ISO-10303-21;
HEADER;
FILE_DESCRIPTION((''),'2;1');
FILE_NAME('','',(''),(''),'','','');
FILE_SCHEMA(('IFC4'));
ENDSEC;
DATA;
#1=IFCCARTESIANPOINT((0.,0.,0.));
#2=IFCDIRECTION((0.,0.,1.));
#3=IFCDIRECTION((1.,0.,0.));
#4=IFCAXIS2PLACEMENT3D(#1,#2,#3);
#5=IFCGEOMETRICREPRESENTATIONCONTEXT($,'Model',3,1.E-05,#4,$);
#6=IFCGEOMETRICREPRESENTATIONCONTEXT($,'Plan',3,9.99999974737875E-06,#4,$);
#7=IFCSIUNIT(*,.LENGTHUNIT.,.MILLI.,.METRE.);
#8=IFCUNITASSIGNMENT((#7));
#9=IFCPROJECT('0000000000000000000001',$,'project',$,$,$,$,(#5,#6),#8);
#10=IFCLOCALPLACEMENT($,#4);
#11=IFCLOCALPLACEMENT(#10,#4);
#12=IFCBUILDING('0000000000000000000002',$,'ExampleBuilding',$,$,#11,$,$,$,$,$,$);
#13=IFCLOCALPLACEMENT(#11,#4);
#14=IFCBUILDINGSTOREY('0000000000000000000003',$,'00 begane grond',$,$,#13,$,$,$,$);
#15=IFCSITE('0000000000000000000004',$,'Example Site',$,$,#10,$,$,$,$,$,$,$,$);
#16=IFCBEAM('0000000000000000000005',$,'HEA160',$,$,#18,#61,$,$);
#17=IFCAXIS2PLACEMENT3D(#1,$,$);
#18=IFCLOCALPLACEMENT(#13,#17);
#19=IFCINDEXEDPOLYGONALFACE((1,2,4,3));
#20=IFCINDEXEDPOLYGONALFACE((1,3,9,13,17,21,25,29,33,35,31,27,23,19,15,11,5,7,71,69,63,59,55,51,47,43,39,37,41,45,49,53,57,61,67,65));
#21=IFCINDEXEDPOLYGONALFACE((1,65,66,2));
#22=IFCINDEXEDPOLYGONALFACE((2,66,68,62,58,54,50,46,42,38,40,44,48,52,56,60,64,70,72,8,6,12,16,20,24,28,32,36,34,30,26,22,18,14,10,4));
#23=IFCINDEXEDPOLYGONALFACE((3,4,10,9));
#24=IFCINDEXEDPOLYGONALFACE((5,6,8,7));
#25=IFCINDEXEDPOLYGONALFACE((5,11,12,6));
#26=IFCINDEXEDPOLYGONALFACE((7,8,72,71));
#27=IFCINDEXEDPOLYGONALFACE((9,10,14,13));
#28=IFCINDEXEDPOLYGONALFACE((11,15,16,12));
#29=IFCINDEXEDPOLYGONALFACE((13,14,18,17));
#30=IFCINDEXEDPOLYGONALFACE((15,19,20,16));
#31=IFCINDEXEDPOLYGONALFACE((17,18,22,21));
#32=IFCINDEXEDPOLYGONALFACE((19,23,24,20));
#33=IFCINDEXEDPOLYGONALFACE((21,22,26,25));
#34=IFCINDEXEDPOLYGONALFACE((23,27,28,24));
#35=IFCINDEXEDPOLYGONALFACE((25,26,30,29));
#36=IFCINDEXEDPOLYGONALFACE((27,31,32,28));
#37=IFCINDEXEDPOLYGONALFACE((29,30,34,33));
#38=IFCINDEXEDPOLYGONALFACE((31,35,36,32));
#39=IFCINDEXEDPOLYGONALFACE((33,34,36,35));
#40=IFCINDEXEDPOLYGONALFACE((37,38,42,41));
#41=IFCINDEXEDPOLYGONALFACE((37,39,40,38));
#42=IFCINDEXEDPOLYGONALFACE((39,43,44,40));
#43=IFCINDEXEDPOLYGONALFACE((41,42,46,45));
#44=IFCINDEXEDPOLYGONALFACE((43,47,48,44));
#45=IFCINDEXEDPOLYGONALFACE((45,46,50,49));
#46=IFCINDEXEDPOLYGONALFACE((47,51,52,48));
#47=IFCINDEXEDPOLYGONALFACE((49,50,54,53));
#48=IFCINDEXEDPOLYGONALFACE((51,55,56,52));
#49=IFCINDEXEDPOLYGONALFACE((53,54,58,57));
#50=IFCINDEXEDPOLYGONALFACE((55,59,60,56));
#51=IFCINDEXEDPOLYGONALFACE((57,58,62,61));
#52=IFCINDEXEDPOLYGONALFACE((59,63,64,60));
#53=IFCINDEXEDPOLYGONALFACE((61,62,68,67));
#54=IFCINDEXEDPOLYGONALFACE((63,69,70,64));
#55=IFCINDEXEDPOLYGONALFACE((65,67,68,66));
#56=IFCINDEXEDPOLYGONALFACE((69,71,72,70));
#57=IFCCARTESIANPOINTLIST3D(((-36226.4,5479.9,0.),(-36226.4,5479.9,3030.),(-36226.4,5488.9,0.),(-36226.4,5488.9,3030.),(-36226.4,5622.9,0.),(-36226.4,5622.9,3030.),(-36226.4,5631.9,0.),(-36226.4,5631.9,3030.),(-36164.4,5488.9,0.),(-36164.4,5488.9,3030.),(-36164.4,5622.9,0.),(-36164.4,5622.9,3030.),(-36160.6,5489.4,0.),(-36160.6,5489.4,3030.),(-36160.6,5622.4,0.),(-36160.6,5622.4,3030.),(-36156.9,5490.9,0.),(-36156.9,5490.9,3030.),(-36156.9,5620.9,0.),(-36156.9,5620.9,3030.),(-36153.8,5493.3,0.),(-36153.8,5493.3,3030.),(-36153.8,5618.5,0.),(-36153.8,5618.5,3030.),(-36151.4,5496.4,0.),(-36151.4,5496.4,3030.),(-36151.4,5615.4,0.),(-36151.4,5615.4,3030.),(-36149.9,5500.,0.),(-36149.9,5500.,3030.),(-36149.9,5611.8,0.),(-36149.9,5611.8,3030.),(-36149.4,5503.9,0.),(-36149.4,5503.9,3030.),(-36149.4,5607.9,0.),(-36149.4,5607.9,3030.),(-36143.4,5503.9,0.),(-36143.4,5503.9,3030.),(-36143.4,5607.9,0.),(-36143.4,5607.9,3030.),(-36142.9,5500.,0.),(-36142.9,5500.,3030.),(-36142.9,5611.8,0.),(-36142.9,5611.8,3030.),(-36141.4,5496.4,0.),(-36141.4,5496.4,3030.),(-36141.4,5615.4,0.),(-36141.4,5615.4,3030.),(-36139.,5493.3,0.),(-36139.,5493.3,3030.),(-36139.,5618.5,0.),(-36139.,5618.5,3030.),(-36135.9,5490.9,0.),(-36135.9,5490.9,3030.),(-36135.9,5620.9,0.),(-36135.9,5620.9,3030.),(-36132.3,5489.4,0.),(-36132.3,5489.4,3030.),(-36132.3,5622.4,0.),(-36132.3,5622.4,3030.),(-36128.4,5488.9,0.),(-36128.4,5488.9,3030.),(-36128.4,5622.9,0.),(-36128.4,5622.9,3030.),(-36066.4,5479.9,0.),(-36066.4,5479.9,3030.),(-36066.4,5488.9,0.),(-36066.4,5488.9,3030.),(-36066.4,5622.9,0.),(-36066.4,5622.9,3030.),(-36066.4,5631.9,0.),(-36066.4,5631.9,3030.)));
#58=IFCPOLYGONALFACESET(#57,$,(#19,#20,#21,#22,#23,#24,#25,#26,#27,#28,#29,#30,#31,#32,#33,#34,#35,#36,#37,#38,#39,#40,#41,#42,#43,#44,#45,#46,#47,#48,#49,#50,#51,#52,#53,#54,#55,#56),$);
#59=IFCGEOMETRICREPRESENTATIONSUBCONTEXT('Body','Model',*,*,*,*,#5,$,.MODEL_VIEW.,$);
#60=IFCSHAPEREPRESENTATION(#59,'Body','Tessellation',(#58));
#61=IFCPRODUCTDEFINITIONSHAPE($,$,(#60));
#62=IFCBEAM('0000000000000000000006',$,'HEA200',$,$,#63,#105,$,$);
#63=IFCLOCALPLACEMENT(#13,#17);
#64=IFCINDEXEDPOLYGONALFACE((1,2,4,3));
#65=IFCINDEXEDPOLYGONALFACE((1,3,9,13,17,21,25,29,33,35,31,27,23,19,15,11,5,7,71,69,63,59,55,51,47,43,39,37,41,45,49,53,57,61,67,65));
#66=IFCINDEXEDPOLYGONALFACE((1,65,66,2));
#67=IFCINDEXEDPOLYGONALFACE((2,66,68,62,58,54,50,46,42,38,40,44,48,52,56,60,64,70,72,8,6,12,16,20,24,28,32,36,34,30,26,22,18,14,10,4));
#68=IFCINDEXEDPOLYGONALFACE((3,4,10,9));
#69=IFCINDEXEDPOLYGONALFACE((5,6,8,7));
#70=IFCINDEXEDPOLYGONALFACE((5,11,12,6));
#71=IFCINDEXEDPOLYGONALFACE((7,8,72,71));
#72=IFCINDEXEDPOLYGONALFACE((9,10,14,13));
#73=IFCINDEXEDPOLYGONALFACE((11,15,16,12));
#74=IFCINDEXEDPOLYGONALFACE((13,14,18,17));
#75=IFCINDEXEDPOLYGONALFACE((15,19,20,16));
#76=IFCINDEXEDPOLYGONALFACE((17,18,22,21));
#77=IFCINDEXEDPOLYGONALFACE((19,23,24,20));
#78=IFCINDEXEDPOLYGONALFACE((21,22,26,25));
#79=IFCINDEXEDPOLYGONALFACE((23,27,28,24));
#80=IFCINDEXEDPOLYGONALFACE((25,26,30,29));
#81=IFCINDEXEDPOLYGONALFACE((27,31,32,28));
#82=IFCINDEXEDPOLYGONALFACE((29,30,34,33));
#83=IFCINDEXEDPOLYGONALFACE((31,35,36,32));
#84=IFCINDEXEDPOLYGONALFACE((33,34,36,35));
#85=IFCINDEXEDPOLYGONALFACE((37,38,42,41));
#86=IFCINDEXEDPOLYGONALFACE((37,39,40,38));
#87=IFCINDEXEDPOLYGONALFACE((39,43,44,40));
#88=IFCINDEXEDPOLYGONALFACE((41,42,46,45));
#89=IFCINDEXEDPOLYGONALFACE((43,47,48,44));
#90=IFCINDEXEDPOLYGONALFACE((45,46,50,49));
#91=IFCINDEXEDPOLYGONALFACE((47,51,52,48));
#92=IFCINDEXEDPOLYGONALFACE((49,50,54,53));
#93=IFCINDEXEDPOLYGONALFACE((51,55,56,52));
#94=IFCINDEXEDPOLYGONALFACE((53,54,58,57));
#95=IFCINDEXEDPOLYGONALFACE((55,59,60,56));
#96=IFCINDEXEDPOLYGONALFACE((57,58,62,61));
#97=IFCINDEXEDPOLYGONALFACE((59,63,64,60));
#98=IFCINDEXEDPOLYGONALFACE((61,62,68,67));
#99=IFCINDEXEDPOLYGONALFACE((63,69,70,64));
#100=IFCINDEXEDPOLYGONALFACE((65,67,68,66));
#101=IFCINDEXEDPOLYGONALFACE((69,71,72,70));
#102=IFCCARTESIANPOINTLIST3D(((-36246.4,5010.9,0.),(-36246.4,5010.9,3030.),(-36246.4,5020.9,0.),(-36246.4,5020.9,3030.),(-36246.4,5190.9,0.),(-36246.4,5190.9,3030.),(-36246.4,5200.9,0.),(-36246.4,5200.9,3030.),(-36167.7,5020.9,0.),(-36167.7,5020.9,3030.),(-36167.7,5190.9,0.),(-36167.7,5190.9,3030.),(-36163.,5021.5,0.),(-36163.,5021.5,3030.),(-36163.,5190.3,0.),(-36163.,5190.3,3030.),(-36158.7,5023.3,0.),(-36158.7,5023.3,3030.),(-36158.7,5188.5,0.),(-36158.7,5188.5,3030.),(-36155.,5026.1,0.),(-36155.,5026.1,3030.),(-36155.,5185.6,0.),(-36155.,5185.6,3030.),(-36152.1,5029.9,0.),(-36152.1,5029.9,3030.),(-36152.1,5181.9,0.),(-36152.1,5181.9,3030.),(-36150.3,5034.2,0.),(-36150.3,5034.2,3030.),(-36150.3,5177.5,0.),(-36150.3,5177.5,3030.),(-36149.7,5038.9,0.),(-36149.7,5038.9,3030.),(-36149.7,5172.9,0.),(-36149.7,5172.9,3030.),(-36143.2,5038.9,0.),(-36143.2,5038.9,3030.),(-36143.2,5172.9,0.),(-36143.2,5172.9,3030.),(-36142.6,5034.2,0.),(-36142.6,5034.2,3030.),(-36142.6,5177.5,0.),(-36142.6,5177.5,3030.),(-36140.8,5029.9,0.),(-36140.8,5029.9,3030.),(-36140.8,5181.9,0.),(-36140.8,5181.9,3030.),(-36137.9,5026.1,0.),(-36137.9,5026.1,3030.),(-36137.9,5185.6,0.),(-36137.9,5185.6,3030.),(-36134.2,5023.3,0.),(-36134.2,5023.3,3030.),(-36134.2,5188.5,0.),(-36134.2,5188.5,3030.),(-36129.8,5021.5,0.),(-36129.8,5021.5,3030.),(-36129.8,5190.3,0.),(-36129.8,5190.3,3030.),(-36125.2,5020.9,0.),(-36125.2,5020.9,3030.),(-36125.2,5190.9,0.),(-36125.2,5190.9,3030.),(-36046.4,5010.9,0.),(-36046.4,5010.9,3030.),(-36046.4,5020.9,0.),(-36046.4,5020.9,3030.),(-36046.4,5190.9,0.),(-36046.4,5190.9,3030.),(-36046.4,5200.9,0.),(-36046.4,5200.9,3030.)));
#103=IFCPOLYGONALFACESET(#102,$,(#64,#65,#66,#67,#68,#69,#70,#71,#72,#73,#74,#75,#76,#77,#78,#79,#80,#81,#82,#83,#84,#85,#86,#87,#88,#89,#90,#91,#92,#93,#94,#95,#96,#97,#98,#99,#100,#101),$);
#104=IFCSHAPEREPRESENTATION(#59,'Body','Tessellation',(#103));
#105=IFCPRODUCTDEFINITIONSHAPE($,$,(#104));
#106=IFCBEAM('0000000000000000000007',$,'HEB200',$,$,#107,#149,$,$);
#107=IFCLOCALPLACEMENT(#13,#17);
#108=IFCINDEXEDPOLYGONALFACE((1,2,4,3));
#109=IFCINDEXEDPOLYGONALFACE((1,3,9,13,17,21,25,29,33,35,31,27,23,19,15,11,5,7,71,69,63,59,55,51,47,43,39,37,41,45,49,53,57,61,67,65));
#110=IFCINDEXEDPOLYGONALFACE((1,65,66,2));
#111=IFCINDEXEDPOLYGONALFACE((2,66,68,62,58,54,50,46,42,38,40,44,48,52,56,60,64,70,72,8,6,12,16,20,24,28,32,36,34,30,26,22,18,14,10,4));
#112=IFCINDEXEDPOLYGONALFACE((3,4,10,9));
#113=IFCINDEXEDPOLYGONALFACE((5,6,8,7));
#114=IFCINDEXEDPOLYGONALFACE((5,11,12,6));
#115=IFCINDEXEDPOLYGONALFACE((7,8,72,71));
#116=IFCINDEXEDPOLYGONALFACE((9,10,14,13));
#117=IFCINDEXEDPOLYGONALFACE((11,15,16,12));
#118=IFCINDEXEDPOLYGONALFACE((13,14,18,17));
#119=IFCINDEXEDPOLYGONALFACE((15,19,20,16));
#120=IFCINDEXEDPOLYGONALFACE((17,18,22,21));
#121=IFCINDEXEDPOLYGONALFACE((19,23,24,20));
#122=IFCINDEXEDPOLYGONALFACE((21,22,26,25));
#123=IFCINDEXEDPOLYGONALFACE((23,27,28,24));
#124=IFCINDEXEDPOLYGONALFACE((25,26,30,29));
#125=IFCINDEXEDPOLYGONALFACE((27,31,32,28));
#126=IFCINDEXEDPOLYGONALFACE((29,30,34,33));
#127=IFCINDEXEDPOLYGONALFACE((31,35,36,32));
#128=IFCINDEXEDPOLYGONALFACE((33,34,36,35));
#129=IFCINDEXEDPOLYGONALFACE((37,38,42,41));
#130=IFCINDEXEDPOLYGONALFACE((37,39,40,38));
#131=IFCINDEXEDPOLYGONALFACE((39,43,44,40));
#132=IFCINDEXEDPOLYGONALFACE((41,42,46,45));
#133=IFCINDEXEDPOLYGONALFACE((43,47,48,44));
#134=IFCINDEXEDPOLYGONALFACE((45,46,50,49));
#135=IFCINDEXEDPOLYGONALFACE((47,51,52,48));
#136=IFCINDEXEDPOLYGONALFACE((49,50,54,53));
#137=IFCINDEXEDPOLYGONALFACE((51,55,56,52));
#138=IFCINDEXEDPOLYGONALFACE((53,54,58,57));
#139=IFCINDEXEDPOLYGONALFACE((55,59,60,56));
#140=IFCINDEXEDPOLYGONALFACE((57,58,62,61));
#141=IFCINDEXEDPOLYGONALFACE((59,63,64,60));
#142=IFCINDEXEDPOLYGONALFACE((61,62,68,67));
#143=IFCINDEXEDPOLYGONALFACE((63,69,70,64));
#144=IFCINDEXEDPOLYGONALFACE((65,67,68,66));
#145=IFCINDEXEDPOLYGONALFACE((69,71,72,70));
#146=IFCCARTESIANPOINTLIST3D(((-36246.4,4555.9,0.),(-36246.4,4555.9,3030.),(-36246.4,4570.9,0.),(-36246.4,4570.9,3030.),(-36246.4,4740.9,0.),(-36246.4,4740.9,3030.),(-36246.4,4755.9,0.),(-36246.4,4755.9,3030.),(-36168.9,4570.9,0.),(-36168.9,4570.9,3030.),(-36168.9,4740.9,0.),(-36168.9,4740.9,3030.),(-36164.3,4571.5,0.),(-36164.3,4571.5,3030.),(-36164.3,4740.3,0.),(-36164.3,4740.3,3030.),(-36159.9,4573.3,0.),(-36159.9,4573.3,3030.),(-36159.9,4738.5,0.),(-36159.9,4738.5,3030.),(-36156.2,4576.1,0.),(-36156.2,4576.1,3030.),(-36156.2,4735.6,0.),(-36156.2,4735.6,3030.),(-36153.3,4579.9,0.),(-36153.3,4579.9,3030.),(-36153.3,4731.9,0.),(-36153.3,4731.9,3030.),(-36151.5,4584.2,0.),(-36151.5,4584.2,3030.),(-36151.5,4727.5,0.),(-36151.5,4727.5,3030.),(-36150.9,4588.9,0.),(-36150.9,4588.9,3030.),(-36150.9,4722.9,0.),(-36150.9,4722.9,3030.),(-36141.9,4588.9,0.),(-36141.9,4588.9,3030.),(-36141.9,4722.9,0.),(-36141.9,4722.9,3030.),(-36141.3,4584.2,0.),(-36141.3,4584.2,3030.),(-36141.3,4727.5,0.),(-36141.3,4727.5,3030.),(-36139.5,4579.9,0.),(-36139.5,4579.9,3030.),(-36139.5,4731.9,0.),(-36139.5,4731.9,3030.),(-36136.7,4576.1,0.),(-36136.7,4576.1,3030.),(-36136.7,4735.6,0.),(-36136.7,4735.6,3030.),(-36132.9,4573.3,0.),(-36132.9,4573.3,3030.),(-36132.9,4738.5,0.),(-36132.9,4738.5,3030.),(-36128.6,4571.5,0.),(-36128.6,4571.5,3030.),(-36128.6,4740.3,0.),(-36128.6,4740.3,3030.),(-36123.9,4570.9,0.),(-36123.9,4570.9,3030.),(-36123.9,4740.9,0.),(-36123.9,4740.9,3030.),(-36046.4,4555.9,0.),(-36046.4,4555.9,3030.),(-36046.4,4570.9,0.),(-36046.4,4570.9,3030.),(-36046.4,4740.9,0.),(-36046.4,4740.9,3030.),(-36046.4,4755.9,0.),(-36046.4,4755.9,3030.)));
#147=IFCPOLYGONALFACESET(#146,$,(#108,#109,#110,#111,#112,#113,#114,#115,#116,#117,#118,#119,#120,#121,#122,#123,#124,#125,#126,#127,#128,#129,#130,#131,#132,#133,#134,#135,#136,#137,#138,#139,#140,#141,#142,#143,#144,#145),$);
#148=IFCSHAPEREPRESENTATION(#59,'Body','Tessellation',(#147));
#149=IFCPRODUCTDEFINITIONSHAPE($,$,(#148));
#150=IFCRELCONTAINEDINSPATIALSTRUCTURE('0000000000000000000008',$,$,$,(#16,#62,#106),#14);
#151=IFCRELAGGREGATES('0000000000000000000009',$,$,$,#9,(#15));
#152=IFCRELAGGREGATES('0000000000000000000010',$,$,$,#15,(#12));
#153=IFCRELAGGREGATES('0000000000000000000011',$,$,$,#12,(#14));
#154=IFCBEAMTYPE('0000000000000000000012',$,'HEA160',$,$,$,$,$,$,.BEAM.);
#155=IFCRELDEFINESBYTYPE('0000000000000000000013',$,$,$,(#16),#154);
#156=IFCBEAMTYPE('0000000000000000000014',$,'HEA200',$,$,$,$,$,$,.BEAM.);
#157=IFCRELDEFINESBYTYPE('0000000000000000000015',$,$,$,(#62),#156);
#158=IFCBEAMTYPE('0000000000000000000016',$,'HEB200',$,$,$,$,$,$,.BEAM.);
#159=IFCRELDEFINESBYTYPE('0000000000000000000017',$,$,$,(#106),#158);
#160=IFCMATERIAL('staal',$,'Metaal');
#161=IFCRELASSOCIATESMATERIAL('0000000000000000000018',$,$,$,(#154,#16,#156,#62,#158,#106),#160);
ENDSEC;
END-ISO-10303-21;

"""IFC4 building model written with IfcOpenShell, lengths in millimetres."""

from ifc_helpers import new_model, si_unit, frame, origin_with_axes, place, context, subcontext, project, spatial, i_section, extrude, material, material_profile, profile_set, profile_usage, type_object, element, save


model = new_model("IFC4")

# Units and contexts
model_context = context("Model", 3, precision=1e-05, world=origin_with_axes())
plan_context = context("Plan", 3, precision=9.99999974737875e-06, world=origin_with_axes())
body_context = subcontext(model_context, "Body", "Model", "MODEL_VIEW")
ifc_project = project(units=[si_unit("LENGTHUNIT", "METRE", prefix="MILLI")], contexts=[model_context, plan_context])

# Site, building, storey
site_placement = place(None, frame((0.0, 0.0, 0.0), z_axis=(0.0, 0.0, 1.0), x_axis=(1.0, 0.0, 0.0)))
site = spatial("IfcSite", under=ifc_project, at=site_placement, Name="Example Site")
building_placement = place(site_placement, frame((0.0, 0.0, 0.0), z_axis=(0.0, 0.0, 1.0), x_axis=(1.0, 0.0, 0.0)))
building = spatial("IfcBuilding", under=site, at=building_placement, Name="ExampleBuilding")
storey_placement = place(building_placement, frame((0.0, 0.0, 0.0), z_axis=(0.0, 0.0, 1.0), x_axis=(1.0, 0.0, 0.0)))
storey = spatial("IfcBuildingStorey", under=building, at=storey_placement, Name="00 begane grond")

# Beams
ifc_material_1 = material(Name="staal", Category="Metaal")
ifc_material_profile_1 = material_profile(ifc_material_1, i_section(OverallWidth=160.0, OverallDepth=152.0, WebThickness=6.0, FlangeThickness=9.0, FilletRadius=15.0))
ifc_profile_set_1 = profile_set([ifc_material_profile_1], Name="staal")
ifc_profile_usage_1 = profile_usage(ifc_profile_set_1, cardinal=5)
beam_type_1 = type_object("IfcBeamType", Name="HEA160", PredefinedType="BEAM", material=ifc_profile_set_1)
beam_1_placement = place(storey_placement, frame((-36146.4, 5555.9, 0.0), z_axis=(-0.000001, 0.0, 1.0), x_axis=(1.0, 0.0, 0.000001)))
element("IfcBeam", 1, at=beam_1_placement, inside=storey, type_object=beam_type_1, material=ifc_profile_usage_1, Name="HEA160", context=body_context, shape_type="SweptSolid", body=[
    extrude(i_section(OverallWidth=160.0, OverallDepth=152.0, WebThickness=6.0, FlangeThickness=9.0, FilletRadius=15.0), origin_with_axes(), (0.0, 0.0, 1.0), 3030.0),
])
ifc_material_profile_2 = material_profile(ifc_material_1, i_section(OverallWidth=200.0, OverallDepth=190.0, WebThickness=6.5, FlangeThickness=10.0, FilletRadius=18.0))
ifc_profile_set_2 = profile_set([ifc_material_profile_2], Name="staal")
ifc_profile_usage_2 = profile_usage(ifc_profile_set_2, cardinal=5)
beam_type_2 = type_object("IfcBeamType", Name="HEA200", PredefinedType="BEAM", material=ifc_profile_set_2)
beam_2_placement = place(storey_placement, frame((-36146.4, 5105.9, 0.0), z_axis=(-0.000001, 0.0, 1.0), x_axis=(1.0, 0.0, 0.000001)))
element("IfcBeam", 2, at=beam_2_placement, inside=storey, type_object=beam_type_2, material=ifc_profile_usage_2, Name="HEA200", context=body_context, shape_type="SweptSolid", body=[
    extrude(i_section(OverallWidth=200.0, OverallDepth=190.0, WebThickness=6.5, FlangeThickness=10.0, FilletRadius=18.0), origin_with_axes(), (0.0, 0.0, 1.0), 3030.0),
])
ifc_material_profile_3 = material_profile(ifc_material_1, i_section(OverallWidth=200.0, OverallDepth=200.0, WebThickness=9.0, FlangeThickness=15.0, FilletRadius=18.0))
ifc_profile_set_3 = profile_set([ifc_material_profile_3], Name="staal")
ifc_profile_usage_3 = profile_usage(ifc_profile_set_3, cardinal=5)
beam_type_3 = type_object("IfcBeamType", Name="HEB200", PredefinedType="BEAM", material=ifc_profile_set_3)
beam_3_placement = place(storey_placement, frame((-36146.4, 4655.9, 0.0), z_axis=(-0.000001, 0.0, 1.0), x_axis=(1.0, 0.0, 0.000001)))
element("IfcBeam", 3, at=beam_3_placement, inside=storey, type_object=beam_type_3, material=ifc_profile_usage_3, Name="HEB200", context=body_context, shape_type="SweptSolid", body=[
    extrude(i_section(OverallWidth=200.0, OverallDepth=200.0, WebThickness=9.0, FlangeThickness=15.0, FilletRadius=18.0), origin_with_axes(), (0.0, 0.0, 1.0), 3030.0),
])

save(model, "model.ifc")
